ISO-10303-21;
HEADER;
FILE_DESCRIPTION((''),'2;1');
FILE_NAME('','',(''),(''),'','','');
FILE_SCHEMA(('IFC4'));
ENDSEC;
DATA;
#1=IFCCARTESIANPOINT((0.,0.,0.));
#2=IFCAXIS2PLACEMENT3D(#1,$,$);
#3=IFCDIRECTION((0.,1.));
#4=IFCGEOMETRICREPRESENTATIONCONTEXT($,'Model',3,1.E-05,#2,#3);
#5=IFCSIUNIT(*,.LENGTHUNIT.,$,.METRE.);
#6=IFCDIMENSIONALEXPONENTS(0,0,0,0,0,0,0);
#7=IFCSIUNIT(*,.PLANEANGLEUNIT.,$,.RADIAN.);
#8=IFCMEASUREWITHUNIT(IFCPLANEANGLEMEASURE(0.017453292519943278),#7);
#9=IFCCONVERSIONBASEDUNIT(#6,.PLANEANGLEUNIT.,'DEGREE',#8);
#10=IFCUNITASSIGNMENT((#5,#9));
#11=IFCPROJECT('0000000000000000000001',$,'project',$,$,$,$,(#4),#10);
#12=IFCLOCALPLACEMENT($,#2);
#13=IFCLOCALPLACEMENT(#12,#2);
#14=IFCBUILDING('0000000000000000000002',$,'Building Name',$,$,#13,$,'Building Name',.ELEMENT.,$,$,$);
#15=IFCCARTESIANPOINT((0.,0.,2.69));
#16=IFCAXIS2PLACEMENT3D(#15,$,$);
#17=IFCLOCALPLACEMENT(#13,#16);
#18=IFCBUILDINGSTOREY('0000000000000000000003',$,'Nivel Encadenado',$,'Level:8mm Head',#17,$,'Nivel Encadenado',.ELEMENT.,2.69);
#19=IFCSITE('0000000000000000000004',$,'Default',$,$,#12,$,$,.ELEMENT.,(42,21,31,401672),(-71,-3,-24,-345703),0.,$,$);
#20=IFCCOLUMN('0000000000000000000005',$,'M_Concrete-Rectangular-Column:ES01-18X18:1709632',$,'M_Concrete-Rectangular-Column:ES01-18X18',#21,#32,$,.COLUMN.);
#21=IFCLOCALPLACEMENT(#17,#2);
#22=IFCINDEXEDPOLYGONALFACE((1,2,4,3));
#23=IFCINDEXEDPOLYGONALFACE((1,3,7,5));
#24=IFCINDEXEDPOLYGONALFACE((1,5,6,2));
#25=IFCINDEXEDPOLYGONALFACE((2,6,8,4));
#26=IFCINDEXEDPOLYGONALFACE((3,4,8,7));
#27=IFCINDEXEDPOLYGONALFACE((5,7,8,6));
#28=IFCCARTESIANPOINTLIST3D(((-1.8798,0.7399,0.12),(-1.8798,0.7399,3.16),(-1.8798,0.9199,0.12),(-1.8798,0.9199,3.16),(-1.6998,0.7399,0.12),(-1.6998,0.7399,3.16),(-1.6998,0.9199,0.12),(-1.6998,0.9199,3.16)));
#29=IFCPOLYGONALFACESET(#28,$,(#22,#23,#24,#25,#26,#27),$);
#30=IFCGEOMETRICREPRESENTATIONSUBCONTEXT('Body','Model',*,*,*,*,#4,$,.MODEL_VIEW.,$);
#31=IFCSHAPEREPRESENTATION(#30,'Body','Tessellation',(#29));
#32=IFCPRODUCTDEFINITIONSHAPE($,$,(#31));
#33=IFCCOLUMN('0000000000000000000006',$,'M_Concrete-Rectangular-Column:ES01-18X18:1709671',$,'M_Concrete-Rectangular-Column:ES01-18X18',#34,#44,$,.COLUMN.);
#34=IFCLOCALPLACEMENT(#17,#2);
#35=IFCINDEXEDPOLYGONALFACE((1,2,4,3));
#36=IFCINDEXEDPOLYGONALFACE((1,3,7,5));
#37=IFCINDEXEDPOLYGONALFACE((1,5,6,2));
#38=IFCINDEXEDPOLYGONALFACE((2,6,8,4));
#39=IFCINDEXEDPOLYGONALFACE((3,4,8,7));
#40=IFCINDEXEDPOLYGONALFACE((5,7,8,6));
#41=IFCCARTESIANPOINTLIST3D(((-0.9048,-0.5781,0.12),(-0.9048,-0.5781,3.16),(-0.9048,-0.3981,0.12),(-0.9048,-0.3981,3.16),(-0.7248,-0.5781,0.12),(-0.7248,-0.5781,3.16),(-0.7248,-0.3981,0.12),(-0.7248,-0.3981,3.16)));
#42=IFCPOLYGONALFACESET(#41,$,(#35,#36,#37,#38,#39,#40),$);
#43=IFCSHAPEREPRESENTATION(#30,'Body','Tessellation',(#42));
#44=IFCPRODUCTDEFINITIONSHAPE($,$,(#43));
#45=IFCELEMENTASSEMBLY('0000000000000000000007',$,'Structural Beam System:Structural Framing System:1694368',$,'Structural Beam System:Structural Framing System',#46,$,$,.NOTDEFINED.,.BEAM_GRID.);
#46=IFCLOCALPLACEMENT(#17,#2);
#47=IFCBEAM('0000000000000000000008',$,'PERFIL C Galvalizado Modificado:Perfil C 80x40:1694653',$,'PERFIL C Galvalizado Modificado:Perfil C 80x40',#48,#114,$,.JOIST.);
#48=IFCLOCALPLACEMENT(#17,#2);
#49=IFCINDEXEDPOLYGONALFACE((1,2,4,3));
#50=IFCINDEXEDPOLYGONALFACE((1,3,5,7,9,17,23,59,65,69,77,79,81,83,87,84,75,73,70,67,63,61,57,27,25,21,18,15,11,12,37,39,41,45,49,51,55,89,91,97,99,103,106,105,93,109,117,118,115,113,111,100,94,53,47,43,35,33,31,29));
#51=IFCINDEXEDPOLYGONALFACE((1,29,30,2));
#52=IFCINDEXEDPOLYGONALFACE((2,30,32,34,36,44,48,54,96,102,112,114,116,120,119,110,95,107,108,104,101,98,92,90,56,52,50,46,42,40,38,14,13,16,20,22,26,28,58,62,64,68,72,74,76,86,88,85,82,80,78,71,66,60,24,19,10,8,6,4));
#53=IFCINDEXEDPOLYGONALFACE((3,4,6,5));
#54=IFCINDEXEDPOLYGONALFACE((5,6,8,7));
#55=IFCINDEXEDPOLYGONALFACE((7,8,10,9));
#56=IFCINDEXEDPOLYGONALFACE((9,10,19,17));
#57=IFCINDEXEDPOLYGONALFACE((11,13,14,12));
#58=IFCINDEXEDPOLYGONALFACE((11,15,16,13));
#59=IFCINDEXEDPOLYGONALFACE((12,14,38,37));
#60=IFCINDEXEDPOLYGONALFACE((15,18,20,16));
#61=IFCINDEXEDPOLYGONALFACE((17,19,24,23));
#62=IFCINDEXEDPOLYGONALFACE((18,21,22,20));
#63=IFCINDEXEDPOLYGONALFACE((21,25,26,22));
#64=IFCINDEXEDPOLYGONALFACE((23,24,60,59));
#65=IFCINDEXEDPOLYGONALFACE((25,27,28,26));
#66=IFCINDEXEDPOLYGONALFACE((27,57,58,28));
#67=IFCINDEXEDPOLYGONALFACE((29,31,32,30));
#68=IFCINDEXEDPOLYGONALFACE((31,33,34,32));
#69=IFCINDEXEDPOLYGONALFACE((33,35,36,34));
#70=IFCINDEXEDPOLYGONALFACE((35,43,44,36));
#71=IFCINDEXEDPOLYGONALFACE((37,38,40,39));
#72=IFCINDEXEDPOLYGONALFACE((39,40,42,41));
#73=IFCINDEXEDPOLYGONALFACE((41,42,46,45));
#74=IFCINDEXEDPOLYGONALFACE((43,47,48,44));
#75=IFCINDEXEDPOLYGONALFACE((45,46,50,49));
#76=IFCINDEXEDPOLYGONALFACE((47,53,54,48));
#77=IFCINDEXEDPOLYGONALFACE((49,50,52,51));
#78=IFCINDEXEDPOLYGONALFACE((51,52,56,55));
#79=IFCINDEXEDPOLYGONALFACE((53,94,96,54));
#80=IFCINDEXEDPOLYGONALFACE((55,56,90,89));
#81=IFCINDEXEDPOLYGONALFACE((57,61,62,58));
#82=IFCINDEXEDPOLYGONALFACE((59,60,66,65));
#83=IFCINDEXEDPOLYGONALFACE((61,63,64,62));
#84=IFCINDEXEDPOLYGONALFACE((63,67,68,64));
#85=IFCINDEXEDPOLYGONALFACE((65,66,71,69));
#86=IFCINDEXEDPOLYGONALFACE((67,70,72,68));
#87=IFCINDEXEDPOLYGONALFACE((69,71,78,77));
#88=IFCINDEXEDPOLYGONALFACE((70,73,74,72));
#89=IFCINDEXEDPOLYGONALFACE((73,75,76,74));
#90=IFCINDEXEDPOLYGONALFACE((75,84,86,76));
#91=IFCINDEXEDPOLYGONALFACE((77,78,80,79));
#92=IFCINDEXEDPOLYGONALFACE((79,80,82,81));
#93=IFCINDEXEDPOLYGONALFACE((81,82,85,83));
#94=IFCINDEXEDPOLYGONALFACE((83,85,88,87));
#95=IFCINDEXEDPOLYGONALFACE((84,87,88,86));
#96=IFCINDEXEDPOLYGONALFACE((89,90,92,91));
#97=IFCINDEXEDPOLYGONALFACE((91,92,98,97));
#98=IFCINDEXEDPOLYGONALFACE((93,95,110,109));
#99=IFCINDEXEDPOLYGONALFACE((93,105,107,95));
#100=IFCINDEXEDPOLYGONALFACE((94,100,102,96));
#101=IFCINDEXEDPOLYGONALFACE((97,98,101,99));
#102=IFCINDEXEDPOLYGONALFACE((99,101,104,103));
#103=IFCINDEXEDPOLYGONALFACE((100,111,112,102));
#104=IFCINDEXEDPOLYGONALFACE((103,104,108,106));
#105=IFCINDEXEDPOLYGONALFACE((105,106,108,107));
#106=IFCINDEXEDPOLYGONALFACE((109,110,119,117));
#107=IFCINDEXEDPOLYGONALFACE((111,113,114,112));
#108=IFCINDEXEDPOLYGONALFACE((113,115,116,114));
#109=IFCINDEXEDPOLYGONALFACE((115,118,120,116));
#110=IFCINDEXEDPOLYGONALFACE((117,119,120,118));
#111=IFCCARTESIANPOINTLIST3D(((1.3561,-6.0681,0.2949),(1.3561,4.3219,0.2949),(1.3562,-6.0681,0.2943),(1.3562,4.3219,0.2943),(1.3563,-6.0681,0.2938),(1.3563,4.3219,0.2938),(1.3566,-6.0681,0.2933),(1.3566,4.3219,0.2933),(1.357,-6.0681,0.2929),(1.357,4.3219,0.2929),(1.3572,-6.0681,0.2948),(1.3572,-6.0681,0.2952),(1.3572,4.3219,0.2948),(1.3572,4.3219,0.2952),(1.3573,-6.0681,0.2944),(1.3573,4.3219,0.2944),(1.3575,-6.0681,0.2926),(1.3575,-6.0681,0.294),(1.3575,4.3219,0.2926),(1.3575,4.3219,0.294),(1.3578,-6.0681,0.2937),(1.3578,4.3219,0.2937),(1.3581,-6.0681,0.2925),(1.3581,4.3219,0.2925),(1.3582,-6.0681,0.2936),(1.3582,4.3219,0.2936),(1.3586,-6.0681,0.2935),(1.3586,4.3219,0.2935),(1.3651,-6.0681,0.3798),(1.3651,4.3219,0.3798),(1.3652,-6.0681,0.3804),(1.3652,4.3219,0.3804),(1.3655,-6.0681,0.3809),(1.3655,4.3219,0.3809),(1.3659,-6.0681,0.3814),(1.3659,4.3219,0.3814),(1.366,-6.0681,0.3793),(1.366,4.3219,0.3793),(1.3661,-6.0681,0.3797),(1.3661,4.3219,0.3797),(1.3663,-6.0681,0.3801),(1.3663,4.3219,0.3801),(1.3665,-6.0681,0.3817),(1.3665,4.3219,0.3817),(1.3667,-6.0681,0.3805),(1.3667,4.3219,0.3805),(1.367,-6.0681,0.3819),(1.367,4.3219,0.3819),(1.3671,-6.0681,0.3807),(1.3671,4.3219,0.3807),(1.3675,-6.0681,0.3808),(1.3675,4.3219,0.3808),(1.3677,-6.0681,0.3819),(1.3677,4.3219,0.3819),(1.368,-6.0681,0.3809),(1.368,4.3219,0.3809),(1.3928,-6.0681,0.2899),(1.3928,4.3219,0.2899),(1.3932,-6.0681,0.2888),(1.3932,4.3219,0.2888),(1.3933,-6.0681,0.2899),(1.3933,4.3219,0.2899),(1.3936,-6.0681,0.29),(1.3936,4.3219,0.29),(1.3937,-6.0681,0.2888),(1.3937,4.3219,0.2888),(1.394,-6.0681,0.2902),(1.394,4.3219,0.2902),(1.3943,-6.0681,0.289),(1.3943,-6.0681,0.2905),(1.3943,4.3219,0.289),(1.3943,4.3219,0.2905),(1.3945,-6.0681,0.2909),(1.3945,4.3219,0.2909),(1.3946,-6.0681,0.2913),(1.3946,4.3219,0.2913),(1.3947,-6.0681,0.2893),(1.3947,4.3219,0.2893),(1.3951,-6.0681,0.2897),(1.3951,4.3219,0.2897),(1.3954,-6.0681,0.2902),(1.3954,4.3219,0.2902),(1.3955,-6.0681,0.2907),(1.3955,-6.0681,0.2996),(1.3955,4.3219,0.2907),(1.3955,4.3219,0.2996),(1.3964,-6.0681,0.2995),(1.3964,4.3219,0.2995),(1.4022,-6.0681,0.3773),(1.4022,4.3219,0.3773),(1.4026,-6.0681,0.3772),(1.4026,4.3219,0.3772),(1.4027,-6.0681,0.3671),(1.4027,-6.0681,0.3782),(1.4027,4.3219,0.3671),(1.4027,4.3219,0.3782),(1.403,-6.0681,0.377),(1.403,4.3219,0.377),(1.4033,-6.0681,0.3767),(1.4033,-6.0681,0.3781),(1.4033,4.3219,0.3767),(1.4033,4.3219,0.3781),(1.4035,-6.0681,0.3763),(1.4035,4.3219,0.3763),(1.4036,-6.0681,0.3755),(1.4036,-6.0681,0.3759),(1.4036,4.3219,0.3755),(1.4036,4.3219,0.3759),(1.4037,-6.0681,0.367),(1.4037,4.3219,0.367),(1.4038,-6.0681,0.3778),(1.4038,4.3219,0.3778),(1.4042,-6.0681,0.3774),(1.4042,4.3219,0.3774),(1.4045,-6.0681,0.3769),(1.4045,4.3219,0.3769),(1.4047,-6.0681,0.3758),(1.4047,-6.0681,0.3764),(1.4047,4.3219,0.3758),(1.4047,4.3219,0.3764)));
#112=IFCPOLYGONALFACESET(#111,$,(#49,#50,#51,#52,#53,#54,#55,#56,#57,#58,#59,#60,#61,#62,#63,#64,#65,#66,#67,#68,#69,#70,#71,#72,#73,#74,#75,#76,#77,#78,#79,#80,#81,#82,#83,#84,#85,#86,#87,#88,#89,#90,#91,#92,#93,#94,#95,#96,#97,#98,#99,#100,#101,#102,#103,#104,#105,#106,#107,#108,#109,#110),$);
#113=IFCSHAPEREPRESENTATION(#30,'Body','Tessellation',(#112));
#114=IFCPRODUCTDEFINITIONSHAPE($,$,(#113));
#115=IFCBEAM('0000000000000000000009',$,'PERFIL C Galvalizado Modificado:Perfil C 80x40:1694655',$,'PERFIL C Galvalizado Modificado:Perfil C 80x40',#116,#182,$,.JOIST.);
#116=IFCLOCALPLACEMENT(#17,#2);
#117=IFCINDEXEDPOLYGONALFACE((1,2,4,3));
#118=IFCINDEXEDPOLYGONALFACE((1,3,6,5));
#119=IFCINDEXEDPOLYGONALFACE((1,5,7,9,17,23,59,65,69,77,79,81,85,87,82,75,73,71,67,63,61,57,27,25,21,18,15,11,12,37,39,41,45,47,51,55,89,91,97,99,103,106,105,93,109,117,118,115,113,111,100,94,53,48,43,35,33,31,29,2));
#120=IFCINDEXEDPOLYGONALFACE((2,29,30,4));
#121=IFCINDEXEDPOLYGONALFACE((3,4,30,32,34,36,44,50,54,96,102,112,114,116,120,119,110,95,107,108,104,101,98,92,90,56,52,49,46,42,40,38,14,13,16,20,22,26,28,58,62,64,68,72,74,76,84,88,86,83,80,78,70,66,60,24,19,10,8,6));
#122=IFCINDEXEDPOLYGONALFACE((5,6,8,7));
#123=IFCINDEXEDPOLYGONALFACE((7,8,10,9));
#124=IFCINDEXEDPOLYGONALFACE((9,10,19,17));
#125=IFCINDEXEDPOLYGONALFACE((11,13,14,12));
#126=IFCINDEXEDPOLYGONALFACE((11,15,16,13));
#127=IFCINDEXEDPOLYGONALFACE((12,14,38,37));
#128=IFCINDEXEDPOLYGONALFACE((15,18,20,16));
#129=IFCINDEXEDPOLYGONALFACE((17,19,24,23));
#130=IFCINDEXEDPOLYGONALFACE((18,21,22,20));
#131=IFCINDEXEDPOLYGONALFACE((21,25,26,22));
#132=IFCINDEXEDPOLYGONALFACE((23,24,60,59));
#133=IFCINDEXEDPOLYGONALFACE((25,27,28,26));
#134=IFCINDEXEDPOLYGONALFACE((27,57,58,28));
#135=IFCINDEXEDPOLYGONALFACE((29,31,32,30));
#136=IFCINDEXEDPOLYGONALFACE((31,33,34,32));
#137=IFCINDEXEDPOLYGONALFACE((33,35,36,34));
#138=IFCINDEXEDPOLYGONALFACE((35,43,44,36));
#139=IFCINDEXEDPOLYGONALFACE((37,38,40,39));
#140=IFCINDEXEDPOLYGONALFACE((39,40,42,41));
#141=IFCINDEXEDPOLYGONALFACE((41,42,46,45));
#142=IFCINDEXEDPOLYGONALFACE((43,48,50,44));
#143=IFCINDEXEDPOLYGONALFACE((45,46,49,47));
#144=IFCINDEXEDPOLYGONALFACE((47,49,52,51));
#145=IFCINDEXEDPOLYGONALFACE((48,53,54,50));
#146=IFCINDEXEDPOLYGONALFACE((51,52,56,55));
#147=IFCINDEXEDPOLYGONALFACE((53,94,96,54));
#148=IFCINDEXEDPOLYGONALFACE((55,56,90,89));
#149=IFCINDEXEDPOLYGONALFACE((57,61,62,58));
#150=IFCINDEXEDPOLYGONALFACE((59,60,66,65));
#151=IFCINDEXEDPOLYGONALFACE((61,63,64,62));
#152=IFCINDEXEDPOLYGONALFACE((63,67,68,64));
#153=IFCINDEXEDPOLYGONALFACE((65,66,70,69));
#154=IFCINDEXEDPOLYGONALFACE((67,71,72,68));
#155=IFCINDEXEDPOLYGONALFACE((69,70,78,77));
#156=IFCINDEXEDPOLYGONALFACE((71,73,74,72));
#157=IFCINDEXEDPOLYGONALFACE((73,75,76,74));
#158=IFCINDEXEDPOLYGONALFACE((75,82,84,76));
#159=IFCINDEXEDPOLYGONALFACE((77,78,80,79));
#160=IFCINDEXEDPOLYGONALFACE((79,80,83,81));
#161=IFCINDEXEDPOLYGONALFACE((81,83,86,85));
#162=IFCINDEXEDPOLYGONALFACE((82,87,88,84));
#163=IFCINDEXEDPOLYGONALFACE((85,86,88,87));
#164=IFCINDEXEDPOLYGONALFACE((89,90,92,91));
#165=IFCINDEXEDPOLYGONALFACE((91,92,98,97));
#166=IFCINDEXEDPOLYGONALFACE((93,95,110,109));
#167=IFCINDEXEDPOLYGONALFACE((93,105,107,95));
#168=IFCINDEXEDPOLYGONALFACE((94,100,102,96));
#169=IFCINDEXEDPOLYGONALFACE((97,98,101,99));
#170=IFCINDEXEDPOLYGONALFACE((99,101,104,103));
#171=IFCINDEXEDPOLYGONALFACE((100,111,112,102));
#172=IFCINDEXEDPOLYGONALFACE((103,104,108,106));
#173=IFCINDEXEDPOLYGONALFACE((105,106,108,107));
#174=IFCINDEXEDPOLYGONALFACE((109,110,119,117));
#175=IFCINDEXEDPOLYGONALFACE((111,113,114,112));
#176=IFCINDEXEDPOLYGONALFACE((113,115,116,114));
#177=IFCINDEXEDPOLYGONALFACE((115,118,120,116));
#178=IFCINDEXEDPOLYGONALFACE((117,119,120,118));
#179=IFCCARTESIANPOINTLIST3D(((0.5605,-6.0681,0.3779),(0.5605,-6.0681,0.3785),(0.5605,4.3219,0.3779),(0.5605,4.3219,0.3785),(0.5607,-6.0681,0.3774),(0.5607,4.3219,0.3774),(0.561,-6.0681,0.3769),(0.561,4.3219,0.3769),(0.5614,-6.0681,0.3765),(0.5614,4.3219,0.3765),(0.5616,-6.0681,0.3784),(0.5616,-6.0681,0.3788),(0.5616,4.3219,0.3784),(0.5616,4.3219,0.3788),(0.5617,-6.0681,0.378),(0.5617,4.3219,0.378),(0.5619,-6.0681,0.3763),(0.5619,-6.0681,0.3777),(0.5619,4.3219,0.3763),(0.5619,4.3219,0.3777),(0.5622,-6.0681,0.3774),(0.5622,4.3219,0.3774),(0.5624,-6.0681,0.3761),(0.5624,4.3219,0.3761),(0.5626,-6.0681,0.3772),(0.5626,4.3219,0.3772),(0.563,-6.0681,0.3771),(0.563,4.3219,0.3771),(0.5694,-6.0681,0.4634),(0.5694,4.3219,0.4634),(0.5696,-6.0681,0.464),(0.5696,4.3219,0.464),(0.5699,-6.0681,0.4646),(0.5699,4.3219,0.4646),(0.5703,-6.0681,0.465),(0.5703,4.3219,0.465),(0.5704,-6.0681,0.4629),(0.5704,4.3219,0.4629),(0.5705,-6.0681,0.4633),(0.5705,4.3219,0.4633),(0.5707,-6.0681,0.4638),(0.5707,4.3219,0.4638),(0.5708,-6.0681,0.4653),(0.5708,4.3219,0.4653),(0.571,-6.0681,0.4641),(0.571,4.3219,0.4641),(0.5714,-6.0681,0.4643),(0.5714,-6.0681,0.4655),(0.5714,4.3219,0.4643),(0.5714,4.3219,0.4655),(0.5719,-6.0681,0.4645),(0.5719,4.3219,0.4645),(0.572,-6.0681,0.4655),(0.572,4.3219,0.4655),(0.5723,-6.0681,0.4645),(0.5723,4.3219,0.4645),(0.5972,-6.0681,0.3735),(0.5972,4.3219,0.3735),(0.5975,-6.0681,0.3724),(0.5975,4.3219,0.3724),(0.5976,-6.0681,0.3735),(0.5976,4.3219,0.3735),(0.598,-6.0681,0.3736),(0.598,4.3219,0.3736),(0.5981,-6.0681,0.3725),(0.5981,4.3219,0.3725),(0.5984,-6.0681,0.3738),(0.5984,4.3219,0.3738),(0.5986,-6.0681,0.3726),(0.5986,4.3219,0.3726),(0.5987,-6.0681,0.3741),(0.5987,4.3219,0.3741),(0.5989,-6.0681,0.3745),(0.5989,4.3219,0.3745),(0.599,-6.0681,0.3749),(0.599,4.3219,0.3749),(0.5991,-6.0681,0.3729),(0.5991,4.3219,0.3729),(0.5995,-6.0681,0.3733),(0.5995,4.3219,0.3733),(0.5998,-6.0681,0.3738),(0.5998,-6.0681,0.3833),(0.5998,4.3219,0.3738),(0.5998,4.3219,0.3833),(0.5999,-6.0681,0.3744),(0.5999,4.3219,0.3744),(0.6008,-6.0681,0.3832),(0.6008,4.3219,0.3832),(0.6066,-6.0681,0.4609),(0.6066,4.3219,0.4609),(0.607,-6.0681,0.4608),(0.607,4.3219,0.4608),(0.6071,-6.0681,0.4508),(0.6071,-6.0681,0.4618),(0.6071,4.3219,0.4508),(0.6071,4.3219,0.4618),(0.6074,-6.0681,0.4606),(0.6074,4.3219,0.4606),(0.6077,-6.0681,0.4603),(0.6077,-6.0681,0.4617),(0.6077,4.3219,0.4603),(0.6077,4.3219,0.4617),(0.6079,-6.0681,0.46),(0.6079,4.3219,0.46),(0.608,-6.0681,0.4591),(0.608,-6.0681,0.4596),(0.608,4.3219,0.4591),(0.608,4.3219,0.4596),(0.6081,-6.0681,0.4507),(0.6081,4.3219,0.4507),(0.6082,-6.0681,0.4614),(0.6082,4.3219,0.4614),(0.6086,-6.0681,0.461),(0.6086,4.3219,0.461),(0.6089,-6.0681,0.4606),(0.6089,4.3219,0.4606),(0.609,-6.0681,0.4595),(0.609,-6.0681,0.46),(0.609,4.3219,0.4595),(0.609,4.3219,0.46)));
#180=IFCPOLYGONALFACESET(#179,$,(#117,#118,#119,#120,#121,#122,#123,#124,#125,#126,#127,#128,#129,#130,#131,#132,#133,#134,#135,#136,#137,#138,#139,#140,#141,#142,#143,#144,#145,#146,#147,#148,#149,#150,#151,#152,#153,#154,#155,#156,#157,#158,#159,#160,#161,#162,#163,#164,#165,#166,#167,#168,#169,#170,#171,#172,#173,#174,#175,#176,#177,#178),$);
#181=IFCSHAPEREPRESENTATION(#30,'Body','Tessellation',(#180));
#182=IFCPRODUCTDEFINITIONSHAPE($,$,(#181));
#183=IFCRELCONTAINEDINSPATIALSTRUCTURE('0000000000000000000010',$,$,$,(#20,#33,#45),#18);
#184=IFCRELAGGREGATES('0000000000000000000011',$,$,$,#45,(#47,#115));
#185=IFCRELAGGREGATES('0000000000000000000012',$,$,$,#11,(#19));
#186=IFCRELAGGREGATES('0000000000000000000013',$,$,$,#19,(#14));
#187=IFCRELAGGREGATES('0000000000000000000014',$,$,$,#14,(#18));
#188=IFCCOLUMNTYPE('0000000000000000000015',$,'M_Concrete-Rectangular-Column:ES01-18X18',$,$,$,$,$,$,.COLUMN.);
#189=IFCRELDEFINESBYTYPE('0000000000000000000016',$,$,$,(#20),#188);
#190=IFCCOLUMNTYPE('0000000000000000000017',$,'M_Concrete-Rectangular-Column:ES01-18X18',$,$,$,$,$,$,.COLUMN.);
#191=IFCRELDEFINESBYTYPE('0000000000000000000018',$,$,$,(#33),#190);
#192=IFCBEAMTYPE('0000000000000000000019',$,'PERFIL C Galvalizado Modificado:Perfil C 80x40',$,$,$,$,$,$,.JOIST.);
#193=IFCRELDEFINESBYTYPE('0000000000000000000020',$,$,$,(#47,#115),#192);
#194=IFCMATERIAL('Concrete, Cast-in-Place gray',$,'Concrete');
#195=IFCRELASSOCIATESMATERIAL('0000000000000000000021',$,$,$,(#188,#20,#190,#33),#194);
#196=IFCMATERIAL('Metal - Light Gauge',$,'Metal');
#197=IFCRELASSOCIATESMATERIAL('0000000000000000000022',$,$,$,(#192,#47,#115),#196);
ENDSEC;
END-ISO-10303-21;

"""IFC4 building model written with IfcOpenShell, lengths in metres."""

from ifc_helpers import new_model, entity, si_unit, converted_unit, direction, frame, origin, place, context, subcontext, project, spatial, line, arc, indexed_curve, outline, extrude, source, transform, mapped, material, type_object, type_shapes, element, aggregate, save


model = new_model("IFC4")

# Units and contexts
model_context = context("Model", 3, precision=1e-05, world=origin(), true_north=direction((0.0, 1.0)))
body_context = subcontext(model_context, "Body", "Model", "MODEL_VIEW")
ifc_project = project(units=[si_unit("LENGTHUNIT", "METRE"), converted_unit("PLANEANGLEUNIT", "DEGREE", entity("IfcPlaneAngleMeasure", 0.017453292519943278), si_unit("PLANEANGLEUNIT", "RADIAN"), dimensions=[0, 0, 0, 0, 0, 0, 0])], contexts=[model_context])

# Site, building, storey
site_placement = place(None, origin())
site = spatial("IfcSite", under=ifc_project, at=site_placement, Name="Default", CompositionType="ELEMENT", RefLatitude=(42, 21, 31, 401672), RefLongitude=(-71, -3, -24, -345703), RefElevation=0.0)
building_placement = place(site_placement, origin())
building = spatial("IfcBuilding", under=site, at=building_placement, Name="Building Name", LongName="Building Name", CompositionType="ELEMENT")
storey_placement = place(building_placement, frame((0.0, 0.0, 2.69)))
storey = spatial("IfcBuildingStorey", under=building, at=storey_placement, Name="Nivel Encadenado", ObjectType="Level:8mm Head", LongName="Nivel Encadenado", CompositionType="ELEMENT", Elevation=2.69)

# Columns
ifc_material_1 = material(Name="Concrete, Cast-in-Place gray", Category="Concrete")
column_type_1 = type_object("IfcColumnType", Name="M_Concrete-Rectangular-Column:ES01-18X18", PredefinedType="COLUMN", material=ifc_material_1)
shared_shape_1 = source(origin(), body_context, "Body", "SweptSolid", [
    extrude(outline(indexed_curve([(-0.09, -0.09), (0.09, -0.09), (0.09, 0.09), (-0.09, 0.09), (-0.09, -0.09)], self_intersect=False)), frame((-1.7898, 0.8299, 2.81), z_axis=(0.0, 0.0, 1.0), x_axis=(-1.0, 0.0, 0.0)), (0.0, 0.0, 1.0), 3.04),
])
type_shapes(column_type_1, [shared_shape_1])
column_1_placement = place(storey_placement, frame((0.0, 0.0, -2.69)))
element("IfcColumn", 1, at=column_1_placement, inside=storey, type_object=column_type_1, material=ifc_material_1, Name="M_Concrete-Rectangular-Column:ES01-18X18:1709632", ObjectType="M_Concrete-Rectangular-Column:ES01-18X18", PredefinedType="COLUMN", context=body_context, shape_type="MappedRepresentation", body=[
    mapped(shared_shape_1, transform((0.0, 0.0, 0.0), scale=1.0)),
])
column_type_2 = type_object("IfcColumnType", Name="M_Concrete-Rectangular-Column:ES01-18X18", PredefinedType="COLUMN", material=ifc_material_1)
shared_shape_2 = source(origin(), body_context, "Body", "SweptSolid", [
    extrude(outline(indexed_curve([(-0.09, -0.09), (0.09, -0.09), (0.09, 0.09), (-0.09, 0.09), (-0.09, -0.09)], self_intersect=False)), frame((-0.8148, -0.4881, 2.81), z_axis=(0.0, 0.0, 1.0), x_axis=(-1.0, 0.0, 0.0)), (0.0, 0.0, 1.0), 3.04),
])
type_shapes(column_type_2, [shared_shape_2])
column_2_placement = place(storey_placement, frame((0.0, 0.0, -2.69)))
element("IfcColumn", 2, at=column_2_placement, inside=storey, type_object=column_type_2, material=ifc_material_1, Name="M_Concrete-Rectangular-Column:ES01-18X18:1709671", ObjectType="M_Concrete-Rectangular-Column:ES01-18X18", PredefinedType="COLUMN", context=body_context, shape_type="MappedRepresentation", body=[
    mapped(shared_shape_2, transform((0.0, 0.0, 0.0), scale=1.0)),
])

# Element assembly, beams
assembly_1_placement = place(storey_placement, origin())
assembly_1 = element("IfcElementAssembly", 3, at=assembly_1_placement, inside=storey, Name="Structural Beam System:Structural Framing System:1694368", ObjectType="Structural Beam System:Structural Framing System", AssemblyPlace="NOTDEFINED", PredefinedType="BEAM_GRID")
ifc_material_2 = material(Name="Metal - Light Gauge", Category="Metal")
beam_type_1 = type_object("IfcBeamType", Name="PERFIL C Galvalizado Modificado:Perfil C 80x40", PredefinedType="JOIST", material=ifc_material_2)
shared_shape_3 = source(origin(), body_context, "Body", "SweptSolid", [
    extrude(outline(indexed_curve([(-0.0428, -0.0237), (0.0426, -0.0237), (0.0443, -0.023), (0.045, -0.0214), (0.045, 0.0139), (0.0443, 0.0154), (0.0428, 0.0161), (0.034, 0.0161), (0.034, 0.0151), (0.0424, 0.0151), (0.0435, 0.0146), (0.044, 0.0135), (0.044, -0.021), (0.0435, -0.0222), (0.0422, -0.0227), (-0.0424, -0.0227), (-0.0435, -0.0223), (-0.0439, -0.0212), (-0.0439, 0.0133), (-0.0435, 0.0144), (-0.0424, 0.0149), (-0.0339, 0.0149), (-0.0339, 0.0159), (-0.0428, 0.0159), (-0.0443, 0.0152), (-0.0449, 0.0137), (-0.0449, -0.0216), (-0.0443, -0.0231)], segments=[line(1, 2), arc(2, 3, 4), line(4, 5), arc(5, 6, 7), line(7, 8, 9, 10), arc(10, 11, 12), line(12, 13), arc(13, 14, 15), line(15, 16), arc(16, 17, 18), line(18, 19), arc(19, 20, 21), line(21, 22, 23, 24), arc(24, 25, 26), line(26, 27), arc(27, 28, 1)], self_intersect=False)), frame((-5.195, -0.0037, 0.0), z_axis=(1.0, 0.0, 0.0), x_axis=(0.0, 0.0, 1.0)), (0.0, 0.0, 1.0), 10.39),
])
type_shapes(beam_type_1, [shared_shape_3])
beam_1_placement = place(assembly_1_placement, frame((1.3805, -0.8731, 0.3353), z_axis=(0.104528, 0.0, 0.994522), x_axis=(0.0, 1.0, 0.0)))
beam_1 = element("IfcBeam", 4, at=beam_1_placement, type_object=beam_type_1, material=ifc_material_2, Name="PERFIL C Galvalizado Modificado:Perfil C 80x40:1694653", ObjectType="PERFIL C Galvalizado Modificado:Perfil C 80x40", PredefinedType="JOIST", context=body_context, shape_type="MappedRepresentation", body=[
    mapped(shared_shape_3, transform((0.0, 0.0, 0.0), scale=1.0)),
])
beam_2_placement = place(assembly_1_placement, frame((0.5849, -0.8731, 0.419), z_axis=(0.104528, 0.0, 0.994522), x_axis=(0.0, 1.0, 0.0)))
beam_2 = element("IfcBeam", 5, at=beam_2_placement, type_object=beam_type_1, material=ifc_material_2, Name="PERFIL C Galvalizado Modificado:Perfil C 80x40:1694655", ObjectType="PERFIL C Galvalizado Modificado:Perfil C 80x40", PredefinedType="JOIST", context=body_context, shape_type="MappedRepresentation", body=[
    mapped(shared_shape_3, transform((0.0, 0.0, 0.0), scale=1.0)),
])
aggregate(assembly_1, [beam_1, beam_2])

save(model, "model.ifc")
